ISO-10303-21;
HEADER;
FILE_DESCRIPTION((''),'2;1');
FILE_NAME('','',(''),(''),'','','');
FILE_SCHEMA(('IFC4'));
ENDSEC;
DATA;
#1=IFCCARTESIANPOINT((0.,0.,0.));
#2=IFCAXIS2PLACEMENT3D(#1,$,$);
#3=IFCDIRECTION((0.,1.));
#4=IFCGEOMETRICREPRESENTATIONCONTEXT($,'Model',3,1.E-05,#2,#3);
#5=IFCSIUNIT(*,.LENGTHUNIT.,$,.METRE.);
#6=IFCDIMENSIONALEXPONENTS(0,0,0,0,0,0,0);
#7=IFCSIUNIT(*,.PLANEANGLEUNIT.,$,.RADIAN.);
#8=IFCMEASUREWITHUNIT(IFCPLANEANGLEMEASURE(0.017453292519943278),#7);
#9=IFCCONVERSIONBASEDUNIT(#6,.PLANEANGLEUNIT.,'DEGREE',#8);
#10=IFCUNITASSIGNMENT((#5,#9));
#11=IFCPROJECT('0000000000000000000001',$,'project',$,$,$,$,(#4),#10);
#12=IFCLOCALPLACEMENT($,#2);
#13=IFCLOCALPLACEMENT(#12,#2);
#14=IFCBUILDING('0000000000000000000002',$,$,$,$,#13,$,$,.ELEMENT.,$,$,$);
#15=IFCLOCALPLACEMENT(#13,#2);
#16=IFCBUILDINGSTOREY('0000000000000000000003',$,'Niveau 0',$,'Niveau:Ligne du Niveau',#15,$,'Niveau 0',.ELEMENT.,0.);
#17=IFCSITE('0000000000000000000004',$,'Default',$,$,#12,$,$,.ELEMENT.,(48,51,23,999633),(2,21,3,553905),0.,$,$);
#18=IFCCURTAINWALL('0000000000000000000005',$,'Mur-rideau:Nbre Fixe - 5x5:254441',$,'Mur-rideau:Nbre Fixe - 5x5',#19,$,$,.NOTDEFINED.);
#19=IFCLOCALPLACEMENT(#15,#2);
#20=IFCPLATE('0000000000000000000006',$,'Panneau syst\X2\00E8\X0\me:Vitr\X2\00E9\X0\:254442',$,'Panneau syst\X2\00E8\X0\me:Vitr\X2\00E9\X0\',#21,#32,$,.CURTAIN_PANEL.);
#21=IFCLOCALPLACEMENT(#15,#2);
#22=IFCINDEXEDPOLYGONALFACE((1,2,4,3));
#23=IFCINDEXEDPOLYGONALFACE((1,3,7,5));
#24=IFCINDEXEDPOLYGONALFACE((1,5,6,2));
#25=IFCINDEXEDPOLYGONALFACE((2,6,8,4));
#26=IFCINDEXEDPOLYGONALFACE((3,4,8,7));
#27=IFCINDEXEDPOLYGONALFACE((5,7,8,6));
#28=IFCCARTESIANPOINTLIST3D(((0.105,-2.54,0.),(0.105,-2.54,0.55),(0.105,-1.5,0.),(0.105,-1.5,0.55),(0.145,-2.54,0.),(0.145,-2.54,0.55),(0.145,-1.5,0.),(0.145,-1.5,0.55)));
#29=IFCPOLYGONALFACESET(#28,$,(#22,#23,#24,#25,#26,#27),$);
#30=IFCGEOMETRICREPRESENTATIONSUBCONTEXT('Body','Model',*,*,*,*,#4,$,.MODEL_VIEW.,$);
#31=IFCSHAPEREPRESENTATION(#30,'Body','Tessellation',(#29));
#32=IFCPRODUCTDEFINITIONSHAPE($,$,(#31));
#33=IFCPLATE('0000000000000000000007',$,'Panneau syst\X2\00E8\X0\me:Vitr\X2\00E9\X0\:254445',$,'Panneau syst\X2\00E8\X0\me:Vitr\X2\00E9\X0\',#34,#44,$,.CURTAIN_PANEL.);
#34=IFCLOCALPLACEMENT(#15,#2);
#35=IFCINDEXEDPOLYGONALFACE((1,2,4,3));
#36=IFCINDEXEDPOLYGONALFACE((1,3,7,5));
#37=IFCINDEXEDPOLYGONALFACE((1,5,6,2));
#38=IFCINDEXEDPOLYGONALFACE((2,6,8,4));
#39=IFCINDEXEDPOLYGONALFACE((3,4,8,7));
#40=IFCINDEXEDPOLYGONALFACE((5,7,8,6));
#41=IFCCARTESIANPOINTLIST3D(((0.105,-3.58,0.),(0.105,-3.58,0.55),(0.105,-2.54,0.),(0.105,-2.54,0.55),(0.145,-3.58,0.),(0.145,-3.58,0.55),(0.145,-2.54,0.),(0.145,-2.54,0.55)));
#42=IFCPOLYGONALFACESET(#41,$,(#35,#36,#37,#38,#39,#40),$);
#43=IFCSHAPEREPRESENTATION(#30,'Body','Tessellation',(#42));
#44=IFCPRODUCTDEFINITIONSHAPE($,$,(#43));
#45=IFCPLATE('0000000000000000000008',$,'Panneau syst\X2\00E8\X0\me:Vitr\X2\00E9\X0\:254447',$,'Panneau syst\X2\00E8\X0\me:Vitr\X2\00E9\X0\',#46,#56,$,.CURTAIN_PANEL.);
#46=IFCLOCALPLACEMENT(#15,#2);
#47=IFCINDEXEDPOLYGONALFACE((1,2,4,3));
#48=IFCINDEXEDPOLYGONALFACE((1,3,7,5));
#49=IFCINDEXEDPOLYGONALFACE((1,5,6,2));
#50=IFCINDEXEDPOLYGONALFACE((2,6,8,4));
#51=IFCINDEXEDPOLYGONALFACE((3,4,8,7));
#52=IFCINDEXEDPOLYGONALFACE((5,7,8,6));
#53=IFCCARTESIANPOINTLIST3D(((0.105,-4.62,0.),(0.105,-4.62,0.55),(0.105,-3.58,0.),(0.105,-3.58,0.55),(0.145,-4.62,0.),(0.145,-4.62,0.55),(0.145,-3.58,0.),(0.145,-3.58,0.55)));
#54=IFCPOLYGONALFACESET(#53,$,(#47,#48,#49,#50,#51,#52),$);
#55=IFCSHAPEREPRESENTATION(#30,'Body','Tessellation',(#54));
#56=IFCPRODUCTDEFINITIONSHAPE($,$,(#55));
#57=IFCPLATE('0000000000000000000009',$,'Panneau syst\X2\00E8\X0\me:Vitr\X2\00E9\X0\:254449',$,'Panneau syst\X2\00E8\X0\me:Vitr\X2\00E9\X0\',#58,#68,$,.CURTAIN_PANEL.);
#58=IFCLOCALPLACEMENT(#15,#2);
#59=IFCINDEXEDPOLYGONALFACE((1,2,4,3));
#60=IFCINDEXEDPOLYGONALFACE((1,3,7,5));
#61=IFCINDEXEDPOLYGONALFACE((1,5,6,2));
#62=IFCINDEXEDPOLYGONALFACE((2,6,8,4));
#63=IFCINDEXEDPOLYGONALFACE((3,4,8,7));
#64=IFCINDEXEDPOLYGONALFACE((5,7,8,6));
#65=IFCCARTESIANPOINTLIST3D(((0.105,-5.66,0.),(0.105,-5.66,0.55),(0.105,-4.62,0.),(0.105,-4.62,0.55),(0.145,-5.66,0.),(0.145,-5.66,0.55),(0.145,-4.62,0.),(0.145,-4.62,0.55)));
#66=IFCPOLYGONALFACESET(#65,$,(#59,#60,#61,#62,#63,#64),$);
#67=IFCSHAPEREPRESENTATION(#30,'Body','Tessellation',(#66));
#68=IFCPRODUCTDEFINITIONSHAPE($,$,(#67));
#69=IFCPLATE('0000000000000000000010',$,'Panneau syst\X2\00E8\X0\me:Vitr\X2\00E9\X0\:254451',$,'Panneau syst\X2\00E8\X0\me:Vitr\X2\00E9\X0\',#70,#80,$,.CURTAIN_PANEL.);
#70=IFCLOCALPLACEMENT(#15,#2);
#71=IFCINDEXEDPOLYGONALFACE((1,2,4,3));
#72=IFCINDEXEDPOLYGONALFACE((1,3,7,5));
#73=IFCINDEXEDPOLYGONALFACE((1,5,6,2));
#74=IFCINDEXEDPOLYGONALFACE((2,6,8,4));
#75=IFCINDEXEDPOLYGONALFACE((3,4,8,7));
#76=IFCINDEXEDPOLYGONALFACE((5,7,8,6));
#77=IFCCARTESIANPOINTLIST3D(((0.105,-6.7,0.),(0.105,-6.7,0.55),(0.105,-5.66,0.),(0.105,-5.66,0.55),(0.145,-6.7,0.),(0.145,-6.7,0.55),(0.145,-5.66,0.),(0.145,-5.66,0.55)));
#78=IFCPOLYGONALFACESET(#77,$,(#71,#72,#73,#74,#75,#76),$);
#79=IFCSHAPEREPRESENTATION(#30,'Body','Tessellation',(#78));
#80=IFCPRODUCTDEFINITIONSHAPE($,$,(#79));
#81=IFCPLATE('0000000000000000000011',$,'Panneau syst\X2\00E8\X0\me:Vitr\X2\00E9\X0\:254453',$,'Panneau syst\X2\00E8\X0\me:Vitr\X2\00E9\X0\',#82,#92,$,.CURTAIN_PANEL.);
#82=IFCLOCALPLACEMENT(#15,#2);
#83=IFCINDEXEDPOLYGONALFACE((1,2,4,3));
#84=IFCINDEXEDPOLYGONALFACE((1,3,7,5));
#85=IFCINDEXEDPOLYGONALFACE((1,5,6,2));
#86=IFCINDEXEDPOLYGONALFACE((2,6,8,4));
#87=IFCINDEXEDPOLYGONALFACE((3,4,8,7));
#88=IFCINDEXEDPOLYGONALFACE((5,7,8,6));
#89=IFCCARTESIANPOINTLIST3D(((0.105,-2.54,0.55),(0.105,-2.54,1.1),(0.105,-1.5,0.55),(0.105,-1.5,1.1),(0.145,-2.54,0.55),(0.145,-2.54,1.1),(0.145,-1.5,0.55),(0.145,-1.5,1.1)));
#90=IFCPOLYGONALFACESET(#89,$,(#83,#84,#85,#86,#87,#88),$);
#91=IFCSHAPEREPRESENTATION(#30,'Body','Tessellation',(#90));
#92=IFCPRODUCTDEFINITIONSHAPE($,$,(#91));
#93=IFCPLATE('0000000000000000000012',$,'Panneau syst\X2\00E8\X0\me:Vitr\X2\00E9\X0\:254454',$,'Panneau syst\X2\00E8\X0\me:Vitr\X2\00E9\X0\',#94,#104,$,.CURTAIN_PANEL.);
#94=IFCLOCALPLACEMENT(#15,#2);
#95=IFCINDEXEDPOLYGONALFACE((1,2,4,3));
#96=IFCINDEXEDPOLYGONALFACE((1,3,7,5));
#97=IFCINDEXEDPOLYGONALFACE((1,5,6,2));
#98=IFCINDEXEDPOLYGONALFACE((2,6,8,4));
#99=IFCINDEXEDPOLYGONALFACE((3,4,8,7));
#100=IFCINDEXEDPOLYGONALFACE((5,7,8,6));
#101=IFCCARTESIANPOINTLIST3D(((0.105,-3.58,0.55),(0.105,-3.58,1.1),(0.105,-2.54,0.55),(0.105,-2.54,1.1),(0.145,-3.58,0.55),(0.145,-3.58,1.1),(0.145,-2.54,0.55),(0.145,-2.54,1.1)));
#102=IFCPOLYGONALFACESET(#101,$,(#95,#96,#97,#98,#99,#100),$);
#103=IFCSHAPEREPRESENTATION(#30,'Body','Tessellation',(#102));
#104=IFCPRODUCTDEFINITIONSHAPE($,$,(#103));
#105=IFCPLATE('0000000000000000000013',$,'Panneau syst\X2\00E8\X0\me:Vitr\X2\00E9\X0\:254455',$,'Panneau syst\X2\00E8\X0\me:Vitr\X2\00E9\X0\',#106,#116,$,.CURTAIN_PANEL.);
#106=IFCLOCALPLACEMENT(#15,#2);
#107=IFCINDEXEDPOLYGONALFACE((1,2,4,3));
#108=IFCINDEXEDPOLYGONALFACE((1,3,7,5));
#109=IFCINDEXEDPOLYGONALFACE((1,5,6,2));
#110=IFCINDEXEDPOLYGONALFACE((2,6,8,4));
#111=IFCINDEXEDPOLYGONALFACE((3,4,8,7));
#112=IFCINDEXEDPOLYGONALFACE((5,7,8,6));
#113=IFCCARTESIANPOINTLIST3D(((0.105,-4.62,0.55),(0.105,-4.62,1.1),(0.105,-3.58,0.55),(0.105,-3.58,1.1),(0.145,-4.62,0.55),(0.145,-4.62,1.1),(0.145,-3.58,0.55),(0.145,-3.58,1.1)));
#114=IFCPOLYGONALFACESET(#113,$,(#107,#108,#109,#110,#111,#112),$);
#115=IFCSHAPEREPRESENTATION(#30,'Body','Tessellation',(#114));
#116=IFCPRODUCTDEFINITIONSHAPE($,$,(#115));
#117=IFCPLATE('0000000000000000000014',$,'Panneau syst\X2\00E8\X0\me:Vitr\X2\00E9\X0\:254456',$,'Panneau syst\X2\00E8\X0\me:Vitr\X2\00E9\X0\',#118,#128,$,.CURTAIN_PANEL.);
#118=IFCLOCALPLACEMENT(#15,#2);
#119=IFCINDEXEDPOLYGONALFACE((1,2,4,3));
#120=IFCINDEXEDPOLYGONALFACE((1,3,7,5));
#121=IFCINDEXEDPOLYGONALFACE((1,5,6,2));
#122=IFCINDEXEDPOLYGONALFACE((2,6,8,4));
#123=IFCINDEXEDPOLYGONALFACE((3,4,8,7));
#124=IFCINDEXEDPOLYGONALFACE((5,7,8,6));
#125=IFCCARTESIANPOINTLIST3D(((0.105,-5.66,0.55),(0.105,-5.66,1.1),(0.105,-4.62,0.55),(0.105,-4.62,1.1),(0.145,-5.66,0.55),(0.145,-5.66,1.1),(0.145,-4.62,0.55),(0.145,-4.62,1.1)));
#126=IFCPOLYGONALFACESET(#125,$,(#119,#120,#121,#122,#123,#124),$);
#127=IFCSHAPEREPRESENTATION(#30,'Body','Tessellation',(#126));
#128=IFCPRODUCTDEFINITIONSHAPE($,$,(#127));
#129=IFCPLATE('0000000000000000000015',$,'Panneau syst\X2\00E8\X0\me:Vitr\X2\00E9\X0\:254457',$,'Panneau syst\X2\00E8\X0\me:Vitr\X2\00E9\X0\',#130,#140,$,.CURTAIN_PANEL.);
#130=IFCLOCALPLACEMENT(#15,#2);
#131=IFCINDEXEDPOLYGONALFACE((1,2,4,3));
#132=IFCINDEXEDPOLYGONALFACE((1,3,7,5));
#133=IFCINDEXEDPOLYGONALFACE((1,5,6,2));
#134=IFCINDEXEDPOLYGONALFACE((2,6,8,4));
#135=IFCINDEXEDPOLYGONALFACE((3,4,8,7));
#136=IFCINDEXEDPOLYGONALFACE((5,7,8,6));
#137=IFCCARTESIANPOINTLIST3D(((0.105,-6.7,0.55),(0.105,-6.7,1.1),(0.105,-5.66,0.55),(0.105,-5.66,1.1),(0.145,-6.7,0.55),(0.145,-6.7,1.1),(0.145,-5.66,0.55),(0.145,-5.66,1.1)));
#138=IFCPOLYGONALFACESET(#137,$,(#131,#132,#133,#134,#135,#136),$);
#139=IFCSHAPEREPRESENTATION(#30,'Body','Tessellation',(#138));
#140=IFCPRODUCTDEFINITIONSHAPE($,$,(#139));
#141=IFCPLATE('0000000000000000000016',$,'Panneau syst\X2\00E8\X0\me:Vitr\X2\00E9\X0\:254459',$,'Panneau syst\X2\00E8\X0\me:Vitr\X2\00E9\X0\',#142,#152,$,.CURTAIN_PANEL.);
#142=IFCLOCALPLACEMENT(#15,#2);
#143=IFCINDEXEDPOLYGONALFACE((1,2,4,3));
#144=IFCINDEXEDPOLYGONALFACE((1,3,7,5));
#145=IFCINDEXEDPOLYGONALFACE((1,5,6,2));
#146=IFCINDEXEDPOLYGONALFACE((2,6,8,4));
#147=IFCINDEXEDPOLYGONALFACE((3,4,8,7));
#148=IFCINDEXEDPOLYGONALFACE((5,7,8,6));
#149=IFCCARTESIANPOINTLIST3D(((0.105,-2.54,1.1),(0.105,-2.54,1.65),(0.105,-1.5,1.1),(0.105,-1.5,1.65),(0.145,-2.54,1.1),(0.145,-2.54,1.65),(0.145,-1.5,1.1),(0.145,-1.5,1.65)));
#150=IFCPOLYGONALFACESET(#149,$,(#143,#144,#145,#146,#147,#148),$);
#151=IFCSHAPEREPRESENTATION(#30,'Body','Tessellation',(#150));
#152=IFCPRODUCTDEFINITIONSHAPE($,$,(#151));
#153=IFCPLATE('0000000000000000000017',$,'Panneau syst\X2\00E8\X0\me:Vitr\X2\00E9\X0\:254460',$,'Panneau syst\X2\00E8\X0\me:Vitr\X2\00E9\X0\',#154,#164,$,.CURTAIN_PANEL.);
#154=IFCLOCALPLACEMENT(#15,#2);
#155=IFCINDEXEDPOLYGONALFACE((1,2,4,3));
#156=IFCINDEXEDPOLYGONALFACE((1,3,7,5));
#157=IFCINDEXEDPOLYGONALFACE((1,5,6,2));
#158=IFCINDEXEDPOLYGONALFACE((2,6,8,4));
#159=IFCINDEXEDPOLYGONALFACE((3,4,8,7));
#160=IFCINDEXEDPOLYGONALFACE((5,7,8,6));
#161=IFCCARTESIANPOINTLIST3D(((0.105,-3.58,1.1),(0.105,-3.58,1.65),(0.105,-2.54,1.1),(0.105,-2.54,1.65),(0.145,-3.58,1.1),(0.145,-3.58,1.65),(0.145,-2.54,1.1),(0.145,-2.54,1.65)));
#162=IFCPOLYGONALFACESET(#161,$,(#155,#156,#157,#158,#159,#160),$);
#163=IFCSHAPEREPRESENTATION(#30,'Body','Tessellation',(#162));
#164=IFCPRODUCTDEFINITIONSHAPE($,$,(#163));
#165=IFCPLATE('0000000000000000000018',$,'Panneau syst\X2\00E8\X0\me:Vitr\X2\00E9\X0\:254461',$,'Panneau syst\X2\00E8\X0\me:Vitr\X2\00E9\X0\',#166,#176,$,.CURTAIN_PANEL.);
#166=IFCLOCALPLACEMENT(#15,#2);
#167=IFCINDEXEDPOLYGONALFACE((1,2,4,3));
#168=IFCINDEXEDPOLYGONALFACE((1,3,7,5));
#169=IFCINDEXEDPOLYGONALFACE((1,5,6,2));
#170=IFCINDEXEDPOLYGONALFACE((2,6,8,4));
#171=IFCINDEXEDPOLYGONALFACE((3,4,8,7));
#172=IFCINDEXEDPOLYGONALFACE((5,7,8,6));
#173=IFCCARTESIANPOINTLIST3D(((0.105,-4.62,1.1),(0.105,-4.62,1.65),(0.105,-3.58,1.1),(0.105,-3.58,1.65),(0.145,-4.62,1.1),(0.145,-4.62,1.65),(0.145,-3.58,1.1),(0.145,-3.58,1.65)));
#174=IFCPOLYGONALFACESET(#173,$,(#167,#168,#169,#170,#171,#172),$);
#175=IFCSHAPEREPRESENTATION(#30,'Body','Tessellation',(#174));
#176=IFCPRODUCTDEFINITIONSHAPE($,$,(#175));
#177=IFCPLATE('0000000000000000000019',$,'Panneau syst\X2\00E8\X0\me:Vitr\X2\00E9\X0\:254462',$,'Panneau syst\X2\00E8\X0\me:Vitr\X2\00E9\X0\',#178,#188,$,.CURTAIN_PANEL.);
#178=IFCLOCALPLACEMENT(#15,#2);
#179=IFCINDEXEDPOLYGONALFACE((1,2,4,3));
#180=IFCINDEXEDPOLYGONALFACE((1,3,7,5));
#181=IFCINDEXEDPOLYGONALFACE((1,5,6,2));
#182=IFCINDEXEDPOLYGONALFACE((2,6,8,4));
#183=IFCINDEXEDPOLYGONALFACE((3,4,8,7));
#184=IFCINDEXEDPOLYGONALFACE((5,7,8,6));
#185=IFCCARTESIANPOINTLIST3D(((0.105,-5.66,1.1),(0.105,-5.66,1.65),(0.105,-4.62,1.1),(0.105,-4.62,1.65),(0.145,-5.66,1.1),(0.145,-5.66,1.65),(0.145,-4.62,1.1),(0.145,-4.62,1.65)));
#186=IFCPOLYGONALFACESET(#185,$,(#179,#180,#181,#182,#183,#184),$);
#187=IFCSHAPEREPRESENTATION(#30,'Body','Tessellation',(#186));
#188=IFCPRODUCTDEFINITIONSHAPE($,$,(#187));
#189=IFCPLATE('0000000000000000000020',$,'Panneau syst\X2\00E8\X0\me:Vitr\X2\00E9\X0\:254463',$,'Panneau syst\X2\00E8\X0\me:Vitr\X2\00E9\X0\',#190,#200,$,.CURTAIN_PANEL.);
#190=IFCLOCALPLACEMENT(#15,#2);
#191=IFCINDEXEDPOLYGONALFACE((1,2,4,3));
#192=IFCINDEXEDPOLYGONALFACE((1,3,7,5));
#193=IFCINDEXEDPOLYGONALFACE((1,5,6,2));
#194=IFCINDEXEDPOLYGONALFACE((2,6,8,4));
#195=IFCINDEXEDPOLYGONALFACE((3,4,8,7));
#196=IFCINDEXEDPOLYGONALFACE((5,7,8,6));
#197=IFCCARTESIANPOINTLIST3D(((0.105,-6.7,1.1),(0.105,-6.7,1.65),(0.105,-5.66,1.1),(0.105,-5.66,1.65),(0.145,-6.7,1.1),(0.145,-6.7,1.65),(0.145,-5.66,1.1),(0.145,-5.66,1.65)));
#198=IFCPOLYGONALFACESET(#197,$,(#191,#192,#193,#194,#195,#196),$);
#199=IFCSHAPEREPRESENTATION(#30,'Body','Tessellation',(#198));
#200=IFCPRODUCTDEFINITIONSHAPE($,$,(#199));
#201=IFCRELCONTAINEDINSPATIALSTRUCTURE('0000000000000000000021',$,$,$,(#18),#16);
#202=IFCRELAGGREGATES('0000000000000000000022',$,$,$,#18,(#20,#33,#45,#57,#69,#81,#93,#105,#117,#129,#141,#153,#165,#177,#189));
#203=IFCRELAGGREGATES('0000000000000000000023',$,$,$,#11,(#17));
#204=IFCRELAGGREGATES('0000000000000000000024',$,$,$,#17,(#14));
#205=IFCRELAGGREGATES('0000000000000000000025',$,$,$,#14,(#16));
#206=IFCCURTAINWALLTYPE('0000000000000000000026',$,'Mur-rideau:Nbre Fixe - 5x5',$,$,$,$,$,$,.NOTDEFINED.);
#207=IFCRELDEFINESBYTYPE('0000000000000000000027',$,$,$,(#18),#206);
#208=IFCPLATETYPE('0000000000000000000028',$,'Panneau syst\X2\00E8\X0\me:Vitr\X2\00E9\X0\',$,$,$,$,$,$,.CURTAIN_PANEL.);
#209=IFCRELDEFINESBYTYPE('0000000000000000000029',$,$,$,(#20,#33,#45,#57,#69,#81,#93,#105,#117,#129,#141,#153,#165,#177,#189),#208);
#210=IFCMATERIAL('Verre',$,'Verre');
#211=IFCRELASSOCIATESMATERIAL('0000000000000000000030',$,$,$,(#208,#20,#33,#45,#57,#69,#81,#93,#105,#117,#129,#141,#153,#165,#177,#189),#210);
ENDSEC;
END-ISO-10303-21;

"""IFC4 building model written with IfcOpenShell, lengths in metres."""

from ifc_helpers import new_model, entity, si_unit, converted_unit, direction, frame, origin, place, context, subcontext, project, spatial, indexed_curve, outline, extrude, source, transform, mapped, material, type_object, type_shapes, element, aggregate, save


model = new_model("IFC4")

# Units and contexts
model_context = context("Model", 3, precision=1e-05, world=origin(), true_north=direction((0.0, 1.0)))
body_context = subcontext(model_context, "Body", "Model", "MODEL_VIEW")
ifc_project = project(units=[si_unit("LENGTHUNIT", "METRE"), converted_unit("PLANEANGLEUNIT", "DEGREE", entity("IfcPlaneAngleMeasure", 0.017453292519943278), si_unit("PLANEANGLEUNIT", "RADIAN"), dimensions=[0, 0, 0, 0, 0, 0, 0])], contexts=[model_context])

# Site, building, storey
site_placement = place(None, origin())
site = spatial("IfcSite", under=ifc_project, at=site_placement, Name="Default", CompositionType="ELEMENT", RefLatitude=(48, 51, 23, 999633), RefLongitude=(2, 21, 3, 553905), RefElevation=0.0)
building_placement = place(site_placement, origin())
building = spatial("IfcBuilding", under=site, at=building_placement, CompositionType="ELEMENT")
storey_placement = place(building_placement, origin())
storey = spatial("IfcBuildingStorey", under=building, at=storey_placement, Name="Niveau 0", ObjectType="Niveau:Ligne du Niveau", LongName="Niveau 0", CompositionType="ELEMENT", Elevation=0.0)

# Curtain wall, plates
curtain_wall_type = type_object("IfcCurtainWallType", Name="Mur-rideau:Nbre Fixe - 5x5", PredefinedType="NOTDEFINED")
curtain_wall_placement = place(storey_placement, origin())
curtain_wall = element("IfcCurtainWall", 1, at=curtain_wall_placement, inside=storey, type_object=curtain_wall_type, Name="Mur-rideau:Nbre Fixe - 5x5:254441", ObjectType="Mur-rideau:Nbre Fixe - 5x5", PredefinedType="NOTDEFINED")
ifc_material_1 = material(Name="Verre", Category="Verre")
plate_type = type_object("IfcPlateType", Name="Panneau système:Vitré", PredefinedType="CURTAIN_PANEL", material=ifc_material_1)
shared_shape = source(origin(), body_context, "Body", "SweptSolid", [
    extrude(outline(indexed_curve([(-0.02, -0.52), (0.02, -0.52), (0.02, 0.52), (-0.02, 0.52), (-0.02, -0.52)], self_intersect=False)), frame((0.52, 0.02, 0.0), z_axis=(0.0, 0.0, 1.0), x_axis=(0.0, 1.0, 0.0)), (0.0, 0.0, 1.0), 0.55),
])
type_shapes(plate_type, [shared_shape])
plate_1_placement = place(curtain_wall_placement, frame((0.105, -1.5, 0.0), z_axis=(0.0, 0.0, 1.0), x_axis=(0.0, -1.0, 0.0)))
plate_1 = element("IfcPlate", 2, at=plate_1_placement, type_object=plate_type, material=ifc_material_1, Name="Panneau système:Vitré:254442", ObjectType="Panneau système:Vitré", PredefinedType="CURTAIN_PANEL", context=body_context, shape_type="MappedRepresentation", body=[
    mapped(shared_shape, transform((0.0, 0.0, 0.0), scale=1.0)),
])
plate_2_placement = place(curtain_wall_placement, frame((0.105, -2.54, 0.0), z_axis=(0.0, 0.0, 1.0), x_axis=(0.0, -1.0, 0.0)))
plate_2 = element("IfcPlate", 3, at=plate_2_placement, type_object=plate_type, material=ifc_material_1, Name="Panneau système:Vitré:254445", ObjectType="Panneau système:Vitré", PredefinedType="CURTAIN_PANEL", context=body_context, shape_type="MappedRepresentation", body=[
    mapped(shared_shape, transform((0.0, 0.0, 0.0), scale=1.0)),
])
plate_3_placement = place(curtain_wall_placement, frame((0.105, -3.58, 0.0), z_axis=(0.0, 0.0, 1.0), x_axis=(0.0, -1.0, 0.0)))
plate_3 = element("IfcPlate", 4, at=plate_3_placement, type_object=plate_type, material=ifc_material_1, Name="Panneau système:Vitré:254447", ObjectType="Panneau système:Vitré", PredefinedType="CURTAIN_PANEL", context=body_context, shape_type="MappedRepresentation", body=[
    mapped(shared_shape, transform((0.0, 0.0, 0.0), scale=1.0)),
])
plate_4_placement = place(curtain_wall_placement, frame((0.105, -4.62, 0.0), z_axis=(0.0, 0.0, 1.0), x_axis=(0.0, -1.0, 0.0)))
plate_4 = element("IfcPlate", 5, at=plate_4_placement, type_object=plate_type, material=ifc_material_1, Name="Panneau système:Vitré:254449", ObjectType="Panneau système:Vitré", PredefinedType="CURTAIN_PANEL", context=body_context, shape_type="MappedRepresentation", body=[
    mapped(shared_shape, transform((0.0, 0.0, 0.0), scale=1.0)),
])
plate_5_placement = place(curtain_wall_placement, frame((0.105, -5.66, 0.0), z_axis=(0.0, 0.0, 1.0), x_axis=(0.0, -1.0, 0.0)))
plate_5 = element("IfcPlate", 6, at=plate_5_placement, type_object=plate_type, material=ifc_material_1, Name="Panneau système:Vitré:254451", ObjectType="Panneau système:Vitré", PredefinedType="CURTAIN_PANEL", context=body_context, shape_type="MappedRepresentation", body=[
    mapped(shared_shape, transform((0.0, 0.0, 0.0), scale=1.0)),
])
plate_6_placement = place(curtain_wall_placement, frame((0.105, -1.5, 0.55), z_axis=(0.0, 0.0, 1.0), x_axis=(0.0, -1.0, 0.0)))
plate_6 = element("IfcPlate", 7, at=plate_6_placement, type_object=plate_type, material=ifc_material_1, Name="Panneau système:Vitré:254453", ObjectType="Panneau système:Vitré", PredefinedType="CURTAIN_PANEL", context=body_context, shape_type="MappedRepresentation", body=[
    mapped(shared_shape, transform((0.0, 0.0, 0.0), scale=1.0)),
])
plate_7_placement = place(curtain_wall_placement, frame((0.105, -2.54, 0.55), z_axis=(0.0, 0.0, 1.0), x_axis=(0.0, -1.0, 0.0)))
plate_7 = element("IfcPlate", 8, at=plate_7_placement, type_object=plate_type, material=ifc_material_1, Name="Panneau système:Vitré:254454", ObjectType="Panneau système:Vitré", PredefinedType="CURTAIN_PANEL", context=body_context, shape_type="MappedRepresentation", body=[
    mapped(shared_shape, transform((0.0, 0.0, 0.0), scale=1.0)),
])
plate_8_placement = place(curtain_wall_placement, frame((0.105, -3.58, 0.55), z_axis=(0.0, 0.0, 1.0), x_axis=(0.0, -1.0, 0.0)))
plate_8 = element("IfcPlate", 9, at=plate_8_placement, type_object=plate_type, material=ifc_material_1, Name="Panneau système:Vitré:254455", ObjectType="Panneau système:Vitré", PredefinedType="CURTAIN_PANEL", context=body_context, shape_type="MappedRepresentation", body=[
    mapped(shared_shape, transform((0.0, 0.0, 0.0), scale=1.0)),
])
plate_9_placement = place(curtain_wall_placement, frame((0.105, -4.62, 0.55), z_axis=(0.0, 0.0, 1.0), x_axis=(0.0, -1.0, 0.0)))
plate_9 = element("IfcPlate", 10, at=plate_9_placement, type_object=plate_type, material=ifc_material_1, Name="Panneau système:Vitré:254456", ObjectType="Panneau système:Vitré", PredefinedType="CURTAIN_PANEL", context=body_context, shape_type="MappedRepresentation", body=[
    mapped(shared_shape, transform((0.0, 0.0, 0.0), scale=1.0)),
])
plate_10_placement = place(curtain_wall_placement, frame((0.105, -5.66, 0.55), z_axis=(0.0, 0.0, 1.0), x_axis=(0.0, -1.0, 0.0)))
plate_10 = element("IfcPlate", 11, at=plate_10_placement, type_object=plate_type, material=ifc_material_1, Name="Panneau système:Vitré:254457", ObjectType="Panneau système:Vitré", PredefinedType="CURTAIN_PANEL", context=body_context, shape_type="MappedRepresentation", body=[
    mapped(shared_shape, transform((0.0, 0.0, 0.0), scale=1.0)),
])
plate_11_placement = place(curtain_wall_placement, frame((0.105, -1.5, 1.1), z_axis=(0.0, 0.0, 1.0), x_axis=(0.0, -1.0, 0.0)))
plate_11 = element("IfcPlate", 12, at=plate_11_placement, type_object=plate_type, material=ifc_material_1, Name="Panneau système:Vitré:254459", ObjectType="Panneau système:Vitré", PredefinedType="CURTAIN_PANEL", context=body_context, shape_type="MappedRepresentation", body=[
    mapped(shared_shape, transform((0.0, 0.0, 0.0), scale=1.0)),
])
plate_12_placement = place(curtain_wall_placement, frame((0.105, -2.54, 1.1), z_axis=(0.0, 0.0, 1.0), x_axis=(0.0, -1.0, 0.0)))
plate_12 = element("IfcPlate", 13, at=plate_12_placement, type_object=plate_type, material=ifc_material_1, Name="Panneau système:Vitré:254460", ObjectType="Panneau système:Vitré", PredefinedType="CURTAIN_PANEL", context=body_context, shape_type="MappedRepresentation", body=[
    mapped(shared_shape, transform((0.0, 0.0, 0.0), scale=1.0)),
])
plate_13_placement = place(curtain_wall_placement, frame((0.105, -3.58, 1.1), z_axis=(0.0, 0.0, 1.0), x_axis=(0.0, -1.0, 0.0)))
plate_13 = element("IfcPlate", 14, at=plate_13_placement, type_object=plate_type, material=ifc_material_1, Name="Panneau système:Vitré:254461", ObjectType="Panneau système:Vitré", PredefinedType="CURTAIN_PANEL", context=body_context, shape_type="MappedRepresentation", body=[
    mapped(shared_shape, transform((0.0, 0.0, 0.0), scale=1.0)),
])
plate_14_placement = place(curtain_wall_placement, frame((0.105, -4.62, 1.1), z_axis=(0.0, 0.0, 1.0), x_axis=(0.0, -1.0, 0.0)))
plate_14 = element("IfcPlate", 15, at=plate_14_placement, type_object=plate_type, material=ifc_material_1, Name="Panneau système:Vitré:254462", ObjectType="Panneau système:Vitré", PredefinedType="CURTAIN_PANEL", context=body_context, shape_type="MappedRepresentation", body=[
    mapped(shared_shape, transform((0.0, 0.0, 0.0), scale=1.0)),
])
plate_15_placement = place(curtain_wall_placement, frame((0.105, -5.66, 1.1), z_axis=(0.0, 0.0, 1.0), x_axis=(0.0, -1.0, 0.0)))
plate_15 = element("IfcPlate", 16, at=plate_15_placement, type_object=plate_type, material=ifc_material_1, Name="Panneau système:Vitré:254463", ObjectType="Panneau système:Vitré", PredefinedType="CURTAIN_PANEL", context=body_context, shape_type="MappedRepresentation", body=[
    mapped(shared_shape, transform((0.0, 0.0, 0.0), scale=1.0)),
])
aggregate(curtain_wall, [plate_1, plate_2, plate_3, plate_4, plate_5, plate_6, plate_7, plate_8, plate_9, plate_10, plate_11, plate_12, plate_13, plate_14, plate_15])

save(model, "model.ifc")
